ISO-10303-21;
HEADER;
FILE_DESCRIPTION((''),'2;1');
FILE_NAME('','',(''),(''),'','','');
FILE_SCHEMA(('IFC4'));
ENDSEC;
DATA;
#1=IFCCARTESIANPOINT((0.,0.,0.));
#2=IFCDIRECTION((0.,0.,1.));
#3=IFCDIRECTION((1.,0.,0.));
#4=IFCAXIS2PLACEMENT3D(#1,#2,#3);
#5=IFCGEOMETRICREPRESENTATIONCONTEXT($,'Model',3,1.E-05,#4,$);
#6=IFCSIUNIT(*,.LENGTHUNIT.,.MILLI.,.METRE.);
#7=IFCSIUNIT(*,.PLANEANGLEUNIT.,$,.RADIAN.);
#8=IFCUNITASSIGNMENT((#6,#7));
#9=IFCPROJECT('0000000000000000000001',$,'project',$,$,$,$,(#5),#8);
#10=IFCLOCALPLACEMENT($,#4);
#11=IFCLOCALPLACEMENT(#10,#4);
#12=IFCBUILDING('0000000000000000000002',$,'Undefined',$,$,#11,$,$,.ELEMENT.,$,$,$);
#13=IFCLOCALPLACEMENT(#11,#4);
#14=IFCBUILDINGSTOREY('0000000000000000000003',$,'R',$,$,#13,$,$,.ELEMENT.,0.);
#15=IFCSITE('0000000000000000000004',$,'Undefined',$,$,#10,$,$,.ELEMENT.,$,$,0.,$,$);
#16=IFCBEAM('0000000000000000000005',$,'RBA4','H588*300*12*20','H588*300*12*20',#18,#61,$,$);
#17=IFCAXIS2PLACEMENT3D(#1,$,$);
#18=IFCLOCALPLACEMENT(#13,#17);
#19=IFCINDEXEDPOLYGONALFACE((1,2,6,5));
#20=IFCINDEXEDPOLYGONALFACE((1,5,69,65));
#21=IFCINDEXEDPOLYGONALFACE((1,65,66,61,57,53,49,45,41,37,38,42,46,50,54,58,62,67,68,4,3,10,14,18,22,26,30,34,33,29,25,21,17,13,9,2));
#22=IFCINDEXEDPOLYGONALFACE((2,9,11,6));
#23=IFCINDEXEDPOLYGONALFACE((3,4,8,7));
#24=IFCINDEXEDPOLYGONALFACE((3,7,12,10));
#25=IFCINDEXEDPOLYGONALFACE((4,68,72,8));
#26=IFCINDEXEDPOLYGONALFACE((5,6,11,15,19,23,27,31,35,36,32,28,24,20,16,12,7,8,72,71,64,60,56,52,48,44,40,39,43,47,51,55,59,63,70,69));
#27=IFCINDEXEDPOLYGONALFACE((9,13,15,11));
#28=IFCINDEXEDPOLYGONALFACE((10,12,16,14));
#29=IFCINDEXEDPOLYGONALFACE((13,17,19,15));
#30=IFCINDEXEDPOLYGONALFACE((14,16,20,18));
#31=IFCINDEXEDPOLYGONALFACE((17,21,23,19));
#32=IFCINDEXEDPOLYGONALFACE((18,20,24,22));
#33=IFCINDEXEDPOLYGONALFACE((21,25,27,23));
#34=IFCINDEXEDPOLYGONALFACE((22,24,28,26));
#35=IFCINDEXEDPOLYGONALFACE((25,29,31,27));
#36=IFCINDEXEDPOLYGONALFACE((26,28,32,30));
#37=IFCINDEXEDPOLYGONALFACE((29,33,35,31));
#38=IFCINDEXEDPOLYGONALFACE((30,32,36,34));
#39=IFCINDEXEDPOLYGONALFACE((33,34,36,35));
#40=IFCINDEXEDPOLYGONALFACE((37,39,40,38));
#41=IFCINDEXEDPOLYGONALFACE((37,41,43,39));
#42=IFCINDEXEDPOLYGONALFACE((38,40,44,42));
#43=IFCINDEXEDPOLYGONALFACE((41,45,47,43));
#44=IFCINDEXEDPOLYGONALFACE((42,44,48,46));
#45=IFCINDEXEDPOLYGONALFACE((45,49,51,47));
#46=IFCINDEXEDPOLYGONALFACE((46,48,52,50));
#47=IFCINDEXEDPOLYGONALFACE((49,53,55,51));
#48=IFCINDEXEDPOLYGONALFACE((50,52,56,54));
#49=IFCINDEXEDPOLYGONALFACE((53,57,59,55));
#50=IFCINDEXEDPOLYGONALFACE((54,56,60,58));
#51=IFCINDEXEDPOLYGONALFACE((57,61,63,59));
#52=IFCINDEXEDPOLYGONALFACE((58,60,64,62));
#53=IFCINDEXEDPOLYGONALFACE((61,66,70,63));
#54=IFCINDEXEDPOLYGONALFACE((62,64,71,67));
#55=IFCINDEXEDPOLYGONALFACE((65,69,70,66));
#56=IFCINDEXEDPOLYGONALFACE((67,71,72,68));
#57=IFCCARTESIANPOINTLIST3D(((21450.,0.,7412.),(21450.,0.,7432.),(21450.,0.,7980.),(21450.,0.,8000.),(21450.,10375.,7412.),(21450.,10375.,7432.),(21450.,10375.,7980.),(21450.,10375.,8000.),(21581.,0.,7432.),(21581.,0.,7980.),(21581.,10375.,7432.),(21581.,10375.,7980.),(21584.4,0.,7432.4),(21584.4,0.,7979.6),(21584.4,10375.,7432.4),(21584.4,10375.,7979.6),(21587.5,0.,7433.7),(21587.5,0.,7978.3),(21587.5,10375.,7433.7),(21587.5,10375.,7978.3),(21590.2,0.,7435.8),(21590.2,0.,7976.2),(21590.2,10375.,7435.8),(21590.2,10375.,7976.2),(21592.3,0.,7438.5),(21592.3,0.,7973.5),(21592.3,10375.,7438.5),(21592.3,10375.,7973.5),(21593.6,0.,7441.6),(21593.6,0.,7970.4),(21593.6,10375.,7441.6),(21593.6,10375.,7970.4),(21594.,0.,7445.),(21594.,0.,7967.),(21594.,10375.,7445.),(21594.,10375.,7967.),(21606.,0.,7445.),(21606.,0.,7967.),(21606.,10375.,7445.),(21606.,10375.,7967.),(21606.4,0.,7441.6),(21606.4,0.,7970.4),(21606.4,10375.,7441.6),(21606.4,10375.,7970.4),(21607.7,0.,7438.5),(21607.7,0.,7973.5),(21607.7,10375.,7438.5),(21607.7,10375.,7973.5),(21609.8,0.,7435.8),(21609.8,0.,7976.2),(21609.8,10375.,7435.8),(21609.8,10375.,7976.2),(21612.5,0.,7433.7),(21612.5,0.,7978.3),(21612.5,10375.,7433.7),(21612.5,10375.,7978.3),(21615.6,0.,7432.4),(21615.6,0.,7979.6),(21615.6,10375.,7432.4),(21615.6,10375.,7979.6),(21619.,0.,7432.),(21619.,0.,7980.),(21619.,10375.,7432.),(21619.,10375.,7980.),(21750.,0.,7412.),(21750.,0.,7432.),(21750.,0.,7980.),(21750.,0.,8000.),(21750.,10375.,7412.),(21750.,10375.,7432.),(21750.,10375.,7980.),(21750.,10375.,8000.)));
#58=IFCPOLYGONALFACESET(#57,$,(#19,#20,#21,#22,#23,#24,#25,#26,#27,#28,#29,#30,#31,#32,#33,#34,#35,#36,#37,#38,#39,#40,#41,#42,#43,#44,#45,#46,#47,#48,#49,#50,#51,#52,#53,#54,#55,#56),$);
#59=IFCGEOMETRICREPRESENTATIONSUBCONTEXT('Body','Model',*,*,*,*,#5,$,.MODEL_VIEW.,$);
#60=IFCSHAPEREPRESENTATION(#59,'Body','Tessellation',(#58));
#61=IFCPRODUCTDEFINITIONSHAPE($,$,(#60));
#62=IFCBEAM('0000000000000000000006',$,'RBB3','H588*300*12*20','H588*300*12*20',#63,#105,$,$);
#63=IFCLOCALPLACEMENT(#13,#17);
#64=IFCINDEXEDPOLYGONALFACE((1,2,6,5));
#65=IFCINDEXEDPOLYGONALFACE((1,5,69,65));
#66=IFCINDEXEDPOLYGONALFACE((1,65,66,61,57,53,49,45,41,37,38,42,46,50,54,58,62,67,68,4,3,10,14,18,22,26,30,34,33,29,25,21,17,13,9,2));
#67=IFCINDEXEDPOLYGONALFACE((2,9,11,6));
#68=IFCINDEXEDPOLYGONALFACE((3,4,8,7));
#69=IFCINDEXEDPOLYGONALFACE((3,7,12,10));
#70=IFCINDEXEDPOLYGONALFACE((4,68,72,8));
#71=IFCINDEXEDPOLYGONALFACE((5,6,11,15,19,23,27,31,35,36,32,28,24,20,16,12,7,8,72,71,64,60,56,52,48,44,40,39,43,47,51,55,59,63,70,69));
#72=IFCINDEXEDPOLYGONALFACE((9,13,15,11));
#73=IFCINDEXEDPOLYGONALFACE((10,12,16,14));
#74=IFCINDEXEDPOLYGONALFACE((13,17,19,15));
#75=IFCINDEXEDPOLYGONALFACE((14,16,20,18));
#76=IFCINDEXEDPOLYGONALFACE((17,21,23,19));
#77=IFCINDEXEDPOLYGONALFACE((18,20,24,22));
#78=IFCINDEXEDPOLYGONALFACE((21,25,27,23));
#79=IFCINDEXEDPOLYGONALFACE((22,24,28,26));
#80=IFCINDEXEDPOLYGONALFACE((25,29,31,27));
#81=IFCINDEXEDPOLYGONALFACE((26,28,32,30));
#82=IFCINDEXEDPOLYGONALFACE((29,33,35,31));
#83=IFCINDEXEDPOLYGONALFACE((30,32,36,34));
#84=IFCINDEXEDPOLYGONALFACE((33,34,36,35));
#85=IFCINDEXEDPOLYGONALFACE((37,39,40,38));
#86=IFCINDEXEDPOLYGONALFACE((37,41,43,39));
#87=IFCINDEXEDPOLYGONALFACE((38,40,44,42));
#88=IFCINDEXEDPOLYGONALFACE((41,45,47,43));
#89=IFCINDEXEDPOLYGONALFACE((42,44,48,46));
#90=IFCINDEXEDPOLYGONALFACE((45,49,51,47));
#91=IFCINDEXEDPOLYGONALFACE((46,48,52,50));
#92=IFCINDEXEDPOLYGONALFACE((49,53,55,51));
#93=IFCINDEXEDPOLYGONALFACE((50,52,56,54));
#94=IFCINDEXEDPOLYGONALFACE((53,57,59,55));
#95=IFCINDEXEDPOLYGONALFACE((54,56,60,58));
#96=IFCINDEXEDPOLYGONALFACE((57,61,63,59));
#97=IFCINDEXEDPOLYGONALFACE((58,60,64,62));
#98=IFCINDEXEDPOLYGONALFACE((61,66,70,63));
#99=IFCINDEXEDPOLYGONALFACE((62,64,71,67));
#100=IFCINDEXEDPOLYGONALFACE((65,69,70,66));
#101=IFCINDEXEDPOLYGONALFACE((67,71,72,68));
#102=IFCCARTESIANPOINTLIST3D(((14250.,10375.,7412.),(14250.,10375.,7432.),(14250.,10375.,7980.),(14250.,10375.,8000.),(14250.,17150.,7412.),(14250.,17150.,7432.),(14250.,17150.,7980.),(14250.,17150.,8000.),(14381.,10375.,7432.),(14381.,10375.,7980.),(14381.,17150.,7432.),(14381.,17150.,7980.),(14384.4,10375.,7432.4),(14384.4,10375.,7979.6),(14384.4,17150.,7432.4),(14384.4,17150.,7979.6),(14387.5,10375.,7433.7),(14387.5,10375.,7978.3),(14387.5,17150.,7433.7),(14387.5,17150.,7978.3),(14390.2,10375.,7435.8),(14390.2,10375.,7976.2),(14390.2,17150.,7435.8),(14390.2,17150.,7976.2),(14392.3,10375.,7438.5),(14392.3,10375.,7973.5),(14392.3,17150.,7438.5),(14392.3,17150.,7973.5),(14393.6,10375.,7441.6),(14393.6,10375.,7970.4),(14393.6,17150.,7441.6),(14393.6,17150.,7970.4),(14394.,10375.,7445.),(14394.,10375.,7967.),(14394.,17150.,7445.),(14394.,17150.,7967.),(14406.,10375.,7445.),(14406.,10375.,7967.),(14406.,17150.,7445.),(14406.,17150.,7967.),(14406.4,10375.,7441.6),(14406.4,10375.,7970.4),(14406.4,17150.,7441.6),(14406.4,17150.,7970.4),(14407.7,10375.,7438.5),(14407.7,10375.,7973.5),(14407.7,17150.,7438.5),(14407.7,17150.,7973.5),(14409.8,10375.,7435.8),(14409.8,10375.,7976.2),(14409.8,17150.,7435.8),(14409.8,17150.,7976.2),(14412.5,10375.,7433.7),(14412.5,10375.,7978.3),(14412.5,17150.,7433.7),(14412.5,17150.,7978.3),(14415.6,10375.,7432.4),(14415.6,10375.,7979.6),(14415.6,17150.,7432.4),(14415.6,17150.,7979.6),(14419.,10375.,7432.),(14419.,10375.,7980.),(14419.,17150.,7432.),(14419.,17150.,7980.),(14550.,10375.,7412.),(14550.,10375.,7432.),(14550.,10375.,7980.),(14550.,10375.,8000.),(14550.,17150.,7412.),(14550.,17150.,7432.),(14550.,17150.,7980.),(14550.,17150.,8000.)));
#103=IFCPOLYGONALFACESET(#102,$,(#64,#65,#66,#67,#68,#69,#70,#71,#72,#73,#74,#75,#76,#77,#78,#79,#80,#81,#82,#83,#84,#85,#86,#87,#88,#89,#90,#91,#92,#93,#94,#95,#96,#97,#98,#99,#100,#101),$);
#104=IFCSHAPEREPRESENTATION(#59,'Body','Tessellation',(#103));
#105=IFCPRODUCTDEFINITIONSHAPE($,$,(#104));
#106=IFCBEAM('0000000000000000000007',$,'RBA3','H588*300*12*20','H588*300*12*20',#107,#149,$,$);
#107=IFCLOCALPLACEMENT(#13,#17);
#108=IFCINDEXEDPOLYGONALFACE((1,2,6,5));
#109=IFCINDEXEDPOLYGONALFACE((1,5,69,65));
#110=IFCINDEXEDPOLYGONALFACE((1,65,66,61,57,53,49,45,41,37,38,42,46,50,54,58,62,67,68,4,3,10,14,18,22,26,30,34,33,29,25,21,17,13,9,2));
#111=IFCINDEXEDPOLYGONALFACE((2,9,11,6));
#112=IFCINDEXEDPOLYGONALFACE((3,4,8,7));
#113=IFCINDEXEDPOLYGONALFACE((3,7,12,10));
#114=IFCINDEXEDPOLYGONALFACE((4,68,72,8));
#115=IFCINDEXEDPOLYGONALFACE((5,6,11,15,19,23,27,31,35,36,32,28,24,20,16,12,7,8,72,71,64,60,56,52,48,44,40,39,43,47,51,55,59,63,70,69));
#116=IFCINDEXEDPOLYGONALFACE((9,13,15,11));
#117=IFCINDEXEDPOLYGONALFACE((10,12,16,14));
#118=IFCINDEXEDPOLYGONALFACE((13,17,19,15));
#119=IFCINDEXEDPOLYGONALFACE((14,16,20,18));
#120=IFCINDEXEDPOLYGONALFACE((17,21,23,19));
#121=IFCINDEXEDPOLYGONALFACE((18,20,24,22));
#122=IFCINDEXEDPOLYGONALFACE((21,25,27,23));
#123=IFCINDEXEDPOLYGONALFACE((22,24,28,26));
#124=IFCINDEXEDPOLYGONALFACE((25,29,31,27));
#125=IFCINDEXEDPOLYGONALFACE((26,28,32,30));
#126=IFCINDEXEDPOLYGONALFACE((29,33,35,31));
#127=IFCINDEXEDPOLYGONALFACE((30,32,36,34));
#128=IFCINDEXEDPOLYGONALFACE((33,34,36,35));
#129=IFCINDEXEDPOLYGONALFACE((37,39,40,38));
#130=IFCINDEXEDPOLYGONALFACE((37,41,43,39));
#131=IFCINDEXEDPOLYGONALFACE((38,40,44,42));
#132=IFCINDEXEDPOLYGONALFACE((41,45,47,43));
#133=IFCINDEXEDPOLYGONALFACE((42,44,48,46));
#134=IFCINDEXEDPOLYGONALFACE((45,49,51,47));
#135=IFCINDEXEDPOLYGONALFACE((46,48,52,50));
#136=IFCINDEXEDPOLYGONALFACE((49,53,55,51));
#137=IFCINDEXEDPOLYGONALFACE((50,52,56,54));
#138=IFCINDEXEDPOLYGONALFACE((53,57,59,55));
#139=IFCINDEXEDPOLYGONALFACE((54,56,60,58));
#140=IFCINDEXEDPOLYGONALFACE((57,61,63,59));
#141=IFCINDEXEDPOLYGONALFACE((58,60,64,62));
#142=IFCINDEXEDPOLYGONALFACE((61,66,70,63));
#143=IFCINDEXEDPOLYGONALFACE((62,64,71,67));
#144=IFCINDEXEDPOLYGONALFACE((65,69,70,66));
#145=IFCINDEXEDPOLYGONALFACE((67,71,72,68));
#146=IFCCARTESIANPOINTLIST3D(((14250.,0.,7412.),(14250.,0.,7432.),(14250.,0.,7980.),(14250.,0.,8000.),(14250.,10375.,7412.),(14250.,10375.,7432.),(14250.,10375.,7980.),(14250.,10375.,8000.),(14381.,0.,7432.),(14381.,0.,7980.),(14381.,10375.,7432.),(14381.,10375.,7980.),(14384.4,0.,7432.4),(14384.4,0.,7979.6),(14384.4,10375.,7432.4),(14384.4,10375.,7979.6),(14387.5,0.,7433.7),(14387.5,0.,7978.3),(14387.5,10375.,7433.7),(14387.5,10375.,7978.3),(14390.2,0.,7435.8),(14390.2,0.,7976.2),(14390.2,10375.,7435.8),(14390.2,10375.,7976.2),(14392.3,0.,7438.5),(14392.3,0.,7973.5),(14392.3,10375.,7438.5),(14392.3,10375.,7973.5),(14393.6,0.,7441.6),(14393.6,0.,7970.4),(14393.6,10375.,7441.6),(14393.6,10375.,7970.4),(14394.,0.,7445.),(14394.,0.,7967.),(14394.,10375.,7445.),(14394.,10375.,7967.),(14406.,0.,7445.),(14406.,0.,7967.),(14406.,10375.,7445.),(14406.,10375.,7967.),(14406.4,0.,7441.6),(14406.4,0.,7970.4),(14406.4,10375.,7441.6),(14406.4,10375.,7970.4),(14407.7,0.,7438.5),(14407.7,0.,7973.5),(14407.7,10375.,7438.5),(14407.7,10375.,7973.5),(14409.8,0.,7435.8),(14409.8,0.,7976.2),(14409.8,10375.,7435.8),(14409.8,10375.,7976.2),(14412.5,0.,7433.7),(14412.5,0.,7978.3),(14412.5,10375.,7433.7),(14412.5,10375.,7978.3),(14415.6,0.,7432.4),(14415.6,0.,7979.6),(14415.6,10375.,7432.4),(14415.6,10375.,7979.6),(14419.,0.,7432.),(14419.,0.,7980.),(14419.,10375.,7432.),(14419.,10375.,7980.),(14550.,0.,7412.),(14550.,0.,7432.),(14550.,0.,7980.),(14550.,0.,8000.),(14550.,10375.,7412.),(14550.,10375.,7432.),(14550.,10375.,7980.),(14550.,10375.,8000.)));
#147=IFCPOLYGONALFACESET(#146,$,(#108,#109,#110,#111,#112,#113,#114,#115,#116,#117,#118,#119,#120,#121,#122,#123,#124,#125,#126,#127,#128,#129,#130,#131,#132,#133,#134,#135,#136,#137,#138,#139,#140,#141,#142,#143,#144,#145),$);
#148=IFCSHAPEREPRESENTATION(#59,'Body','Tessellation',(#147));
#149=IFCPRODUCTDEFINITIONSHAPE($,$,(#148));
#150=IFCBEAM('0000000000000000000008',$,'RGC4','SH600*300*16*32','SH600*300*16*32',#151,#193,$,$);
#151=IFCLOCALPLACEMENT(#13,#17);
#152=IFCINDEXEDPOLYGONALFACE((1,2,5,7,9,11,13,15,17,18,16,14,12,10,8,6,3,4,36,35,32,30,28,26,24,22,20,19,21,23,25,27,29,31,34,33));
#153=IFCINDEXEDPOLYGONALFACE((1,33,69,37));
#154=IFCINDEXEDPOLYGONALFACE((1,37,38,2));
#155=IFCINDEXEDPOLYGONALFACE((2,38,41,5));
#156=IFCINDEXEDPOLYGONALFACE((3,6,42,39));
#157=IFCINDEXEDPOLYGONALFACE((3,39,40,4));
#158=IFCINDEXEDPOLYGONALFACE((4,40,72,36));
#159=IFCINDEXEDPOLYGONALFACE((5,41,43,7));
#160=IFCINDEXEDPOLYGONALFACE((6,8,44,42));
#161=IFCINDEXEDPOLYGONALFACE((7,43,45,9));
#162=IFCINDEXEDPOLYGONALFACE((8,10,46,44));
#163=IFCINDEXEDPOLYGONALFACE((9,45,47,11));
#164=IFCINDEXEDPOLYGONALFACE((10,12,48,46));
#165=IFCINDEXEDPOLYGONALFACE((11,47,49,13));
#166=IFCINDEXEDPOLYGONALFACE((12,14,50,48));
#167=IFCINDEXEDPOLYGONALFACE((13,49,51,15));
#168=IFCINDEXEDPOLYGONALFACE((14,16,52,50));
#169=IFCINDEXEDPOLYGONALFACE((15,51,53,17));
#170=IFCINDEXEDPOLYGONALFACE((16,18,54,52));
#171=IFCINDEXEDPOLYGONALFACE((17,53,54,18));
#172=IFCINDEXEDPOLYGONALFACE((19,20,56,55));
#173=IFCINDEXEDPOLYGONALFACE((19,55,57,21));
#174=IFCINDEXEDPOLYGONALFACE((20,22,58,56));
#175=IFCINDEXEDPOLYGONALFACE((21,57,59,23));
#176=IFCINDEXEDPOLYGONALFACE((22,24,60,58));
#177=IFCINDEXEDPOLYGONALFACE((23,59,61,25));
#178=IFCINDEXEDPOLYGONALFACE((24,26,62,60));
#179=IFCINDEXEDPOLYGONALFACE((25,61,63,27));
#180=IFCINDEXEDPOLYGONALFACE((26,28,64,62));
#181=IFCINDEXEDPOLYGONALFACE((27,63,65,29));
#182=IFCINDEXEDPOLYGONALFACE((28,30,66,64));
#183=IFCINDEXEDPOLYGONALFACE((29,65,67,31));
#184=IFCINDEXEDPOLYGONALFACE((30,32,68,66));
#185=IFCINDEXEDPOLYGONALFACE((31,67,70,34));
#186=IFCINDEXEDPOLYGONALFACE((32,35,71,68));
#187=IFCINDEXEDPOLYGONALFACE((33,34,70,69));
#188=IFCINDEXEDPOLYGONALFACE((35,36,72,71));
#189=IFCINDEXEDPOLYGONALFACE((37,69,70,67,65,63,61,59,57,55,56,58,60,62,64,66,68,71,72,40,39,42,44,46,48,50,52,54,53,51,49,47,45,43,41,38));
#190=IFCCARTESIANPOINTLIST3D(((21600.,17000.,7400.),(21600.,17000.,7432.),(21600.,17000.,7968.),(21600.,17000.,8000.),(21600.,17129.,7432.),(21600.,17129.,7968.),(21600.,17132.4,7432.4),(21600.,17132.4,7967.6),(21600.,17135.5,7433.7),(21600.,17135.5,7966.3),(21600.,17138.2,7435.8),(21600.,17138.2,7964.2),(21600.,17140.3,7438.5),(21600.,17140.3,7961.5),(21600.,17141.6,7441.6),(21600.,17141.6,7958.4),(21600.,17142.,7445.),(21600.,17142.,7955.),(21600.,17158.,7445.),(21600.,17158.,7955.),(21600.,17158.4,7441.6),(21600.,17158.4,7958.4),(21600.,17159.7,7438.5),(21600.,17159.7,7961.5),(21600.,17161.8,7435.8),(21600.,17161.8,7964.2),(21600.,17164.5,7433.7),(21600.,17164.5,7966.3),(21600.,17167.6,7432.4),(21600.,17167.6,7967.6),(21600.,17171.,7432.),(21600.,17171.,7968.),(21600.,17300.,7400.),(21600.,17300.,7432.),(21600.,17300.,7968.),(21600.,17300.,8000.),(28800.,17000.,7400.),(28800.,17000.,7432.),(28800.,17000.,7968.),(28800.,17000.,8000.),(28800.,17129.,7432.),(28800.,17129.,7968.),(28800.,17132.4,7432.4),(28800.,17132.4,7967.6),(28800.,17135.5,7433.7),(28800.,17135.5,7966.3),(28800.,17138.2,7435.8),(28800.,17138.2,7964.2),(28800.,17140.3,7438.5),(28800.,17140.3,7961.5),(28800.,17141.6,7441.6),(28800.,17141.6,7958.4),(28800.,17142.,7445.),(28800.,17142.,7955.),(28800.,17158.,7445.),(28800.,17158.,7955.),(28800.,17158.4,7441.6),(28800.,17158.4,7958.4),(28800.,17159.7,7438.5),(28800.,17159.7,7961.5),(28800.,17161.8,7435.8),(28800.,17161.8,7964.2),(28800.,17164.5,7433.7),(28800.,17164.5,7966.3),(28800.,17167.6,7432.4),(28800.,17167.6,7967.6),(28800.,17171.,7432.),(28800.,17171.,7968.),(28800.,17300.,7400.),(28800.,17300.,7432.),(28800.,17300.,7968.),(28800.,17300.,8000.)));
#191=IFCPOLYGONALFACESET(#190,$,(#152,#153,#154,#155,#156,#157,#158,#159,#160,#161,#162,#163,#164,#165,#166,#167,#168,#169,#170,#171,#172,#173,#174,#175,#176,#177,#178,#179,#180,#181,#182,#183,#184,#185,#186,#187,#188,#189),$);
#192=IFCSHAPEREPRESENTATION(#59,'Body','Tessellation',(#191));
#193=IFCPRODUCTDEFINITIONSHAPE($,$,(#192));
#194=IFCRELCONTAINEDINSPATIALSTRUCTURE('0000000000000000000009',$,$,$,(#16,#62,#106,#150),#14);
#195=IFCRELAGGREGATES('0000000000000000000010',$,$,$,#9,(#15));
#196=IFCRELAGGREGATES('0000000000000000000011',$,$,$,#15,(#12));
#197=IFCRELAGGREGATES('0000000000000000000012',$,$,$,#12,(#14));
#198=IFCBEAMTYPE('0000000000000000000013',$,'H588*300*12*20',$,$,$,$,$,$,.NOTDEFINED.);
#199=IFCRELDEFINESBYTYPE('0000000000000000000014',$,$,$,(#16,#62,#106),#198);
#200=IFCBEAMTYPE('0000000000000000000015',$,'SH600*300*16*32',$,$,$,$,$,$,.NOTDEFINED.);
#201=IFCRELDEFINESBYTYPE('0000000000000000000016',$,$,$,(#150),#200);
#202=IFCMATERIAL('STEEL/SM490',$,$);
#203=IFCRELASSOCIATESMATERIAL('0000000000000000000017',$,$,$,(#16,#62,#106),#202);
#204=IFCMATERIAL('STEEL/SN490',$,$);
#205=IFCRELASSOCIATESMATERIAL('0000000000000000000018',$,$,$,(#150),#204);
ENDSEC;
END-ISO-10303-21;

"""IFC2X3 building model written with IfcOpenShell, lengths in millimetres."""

from ifc_helpers import new_model, si_unit, frame, origin_with_axes, origin_2d_with_axis, place, context, subcontext, project, spatial, i_section, extrude, material, type_object, element, save


model = new_model("IFC2X3")

# Units and contexts
model_context = context("Model", 3, precision=1e-05, world=origin_with_axes())
body_context = subcontext(model_context, "Body", "Model", "MODEL_VIEW")
ifc_project = project(units=[si_unit("LENGTHUNIT", "METRE", prefix="MILLI"), si_unit("PLANEANGLEUNIT", "RADIAN")], contexts=[model_context])

# Site, building, storey
site_placement = place(None, origin_with_axes())
site = spatial("IfcSite", under=ifc_project, at=site_placement, Name="Undefined", CompositionType="ELEMENT", RefElevation=0.0)
building_placement = place(site_placement, origin_with_axes())
building = spatial("IfcBuilding", under=site, at=building_placement, Name="Undefined", CompositionType="ELEMENT")
storey_placement = place(building_placement, origin_with_axes())
storey = spatial("IfcBuildingStorey", under=building, at=storey_placement, Name="R", CompositionType="ELEMENT", Elevation=0.0)

# Beams
ifc_material_1 = material(Name="STEEL/SM490")
beam_type_1 = type_object("IfcBeamType", Name="H588*300*12*20", PredefinedType="NOTDEFINED")
beam_1_placement = place(storey_placement, frame((21600.0, 0.0, 7706.0), z_axis=(0.0, 0.0, 1.0), x_axis=(0.0, 1.0, 0.0)))
element("IfcBeam", 1, at=beam_1_placement, inside=storey, type_object=beam_type_1, material=ifc_material_1, Name="RBA4", Description="H588*300*12*20", ObjectType="H588*300*12*20", context=body_context, shape_type="SweptSolid", body=[
    extrude(i_section(OverallWidth=300.0, OverallDepth=588.0, WebThickness=12.0, FlangeThickness=20.0, FilletRadius=13.0, at=origin_2d_with_axis()), frame((10375.0, 0.0, 0.0), z_axis=(-1.0, 0.0, 0.0), x_axis=(0.0, -1.0, 0.0)), (0.0, 0.0, 1.0), 10375.0),
])
beam_2_placement = place(storey_placement, frame((14400.0, 10375.0, 7706.0), z_axis=(0.0, 0.0, 1.0), x_axis=(0.0, 1.0, 0.0)))
element("IfcBeam", 2, at=beam_2_placement, inside=storey, type_object=beam_type_1, material=ifc_material_1, Name="RBB3", Description="H588*300*12*20", ObjectType="H588*300*12*20", context=body_context, shape_type="SweptSolid", body=[
    extrude(i_section(OverallWidth=300.0, OverallDepth=588.0, WebThickness=12.0, FlangeThickness=20.0, FilletRadius=13.0, at=origin_2d_with_axis()), frame((6775.0, 0.0, 0.0), z_axis=(-1.0, 0.0, 0.0), x_axis=(0.0, -1.0, 0.0)), (0.0, 0.0, 1.0), 6775.0),
])
beam_3_placement = place(storey_placement, frame((14400.0, 0.0, 7706.0), z_axis=(0.0, 0.0, 1.0), x_axis=(0.0, 1.0, 0.0)))
element("IfcBeam", 3, at=beam_3_placement, inside=storey, type_object=beam_type_1, material=ifc_material_1, Name="RBA3", Description="H588*300*12*20", ObjectType="H588*300*12*20", context=body_context, shape_type="SweptSolid", body=[
    extrude(i_section(OverallWidth=300.0, OverallDepth=588.0, WebThickness=12.0, FlangeThickness=20.0, FilletRadius=13.0, at=origin_2d_with_axis()), frame((10375.0, 0.0, 0.0), z_axis=(-1.0, 0.0, 0.0), x_axis=(0.0, -1.0, 0.0)), (0.0, 0.0, 1.0), 10375.0),
])
ifc_material_2 = material(Name="STEEL/SN490")
beam_type_2 = type_object("IfcBeamType", Name="SH600*300*16*32", PredefinedType="NOTDEFINED")
for number, where, z_axis, x_axis, name in (
    (4, (21600.0, 17150.0, 7700.0), (0.0, 0.0, 1.0), (1.0, 0.0, 0.0), "RGC4"),
):
    element("IfcBeam", number, at=place(storey_placement, frame(where, z_axis=z_axis, x_axis=x_axis)), inside=storey, type_object=beam_type_2, material=ifc_material_2, Name=name, Description="SH600*300*16*32", ObjectType="SH600*300*16*32", context=body_context, shape_type="SweptSolid", body=[
        extrude(i_section(OverallWidth=300.0, OverallDepth=600.0, WebThickness=16.0, FlangeThickness=32.0, FilletRadius=13.0, at=origin_2d_with_axis()), frame((7200.0, 0.0, 0.0), z_axis=(-1.0, 0.0, 0.0), x_axis=(0.0, -1.0, 0.0)), (0.0, 0.0, 1.0), 7200.0),
    ])

save(model, "model.ifc")
